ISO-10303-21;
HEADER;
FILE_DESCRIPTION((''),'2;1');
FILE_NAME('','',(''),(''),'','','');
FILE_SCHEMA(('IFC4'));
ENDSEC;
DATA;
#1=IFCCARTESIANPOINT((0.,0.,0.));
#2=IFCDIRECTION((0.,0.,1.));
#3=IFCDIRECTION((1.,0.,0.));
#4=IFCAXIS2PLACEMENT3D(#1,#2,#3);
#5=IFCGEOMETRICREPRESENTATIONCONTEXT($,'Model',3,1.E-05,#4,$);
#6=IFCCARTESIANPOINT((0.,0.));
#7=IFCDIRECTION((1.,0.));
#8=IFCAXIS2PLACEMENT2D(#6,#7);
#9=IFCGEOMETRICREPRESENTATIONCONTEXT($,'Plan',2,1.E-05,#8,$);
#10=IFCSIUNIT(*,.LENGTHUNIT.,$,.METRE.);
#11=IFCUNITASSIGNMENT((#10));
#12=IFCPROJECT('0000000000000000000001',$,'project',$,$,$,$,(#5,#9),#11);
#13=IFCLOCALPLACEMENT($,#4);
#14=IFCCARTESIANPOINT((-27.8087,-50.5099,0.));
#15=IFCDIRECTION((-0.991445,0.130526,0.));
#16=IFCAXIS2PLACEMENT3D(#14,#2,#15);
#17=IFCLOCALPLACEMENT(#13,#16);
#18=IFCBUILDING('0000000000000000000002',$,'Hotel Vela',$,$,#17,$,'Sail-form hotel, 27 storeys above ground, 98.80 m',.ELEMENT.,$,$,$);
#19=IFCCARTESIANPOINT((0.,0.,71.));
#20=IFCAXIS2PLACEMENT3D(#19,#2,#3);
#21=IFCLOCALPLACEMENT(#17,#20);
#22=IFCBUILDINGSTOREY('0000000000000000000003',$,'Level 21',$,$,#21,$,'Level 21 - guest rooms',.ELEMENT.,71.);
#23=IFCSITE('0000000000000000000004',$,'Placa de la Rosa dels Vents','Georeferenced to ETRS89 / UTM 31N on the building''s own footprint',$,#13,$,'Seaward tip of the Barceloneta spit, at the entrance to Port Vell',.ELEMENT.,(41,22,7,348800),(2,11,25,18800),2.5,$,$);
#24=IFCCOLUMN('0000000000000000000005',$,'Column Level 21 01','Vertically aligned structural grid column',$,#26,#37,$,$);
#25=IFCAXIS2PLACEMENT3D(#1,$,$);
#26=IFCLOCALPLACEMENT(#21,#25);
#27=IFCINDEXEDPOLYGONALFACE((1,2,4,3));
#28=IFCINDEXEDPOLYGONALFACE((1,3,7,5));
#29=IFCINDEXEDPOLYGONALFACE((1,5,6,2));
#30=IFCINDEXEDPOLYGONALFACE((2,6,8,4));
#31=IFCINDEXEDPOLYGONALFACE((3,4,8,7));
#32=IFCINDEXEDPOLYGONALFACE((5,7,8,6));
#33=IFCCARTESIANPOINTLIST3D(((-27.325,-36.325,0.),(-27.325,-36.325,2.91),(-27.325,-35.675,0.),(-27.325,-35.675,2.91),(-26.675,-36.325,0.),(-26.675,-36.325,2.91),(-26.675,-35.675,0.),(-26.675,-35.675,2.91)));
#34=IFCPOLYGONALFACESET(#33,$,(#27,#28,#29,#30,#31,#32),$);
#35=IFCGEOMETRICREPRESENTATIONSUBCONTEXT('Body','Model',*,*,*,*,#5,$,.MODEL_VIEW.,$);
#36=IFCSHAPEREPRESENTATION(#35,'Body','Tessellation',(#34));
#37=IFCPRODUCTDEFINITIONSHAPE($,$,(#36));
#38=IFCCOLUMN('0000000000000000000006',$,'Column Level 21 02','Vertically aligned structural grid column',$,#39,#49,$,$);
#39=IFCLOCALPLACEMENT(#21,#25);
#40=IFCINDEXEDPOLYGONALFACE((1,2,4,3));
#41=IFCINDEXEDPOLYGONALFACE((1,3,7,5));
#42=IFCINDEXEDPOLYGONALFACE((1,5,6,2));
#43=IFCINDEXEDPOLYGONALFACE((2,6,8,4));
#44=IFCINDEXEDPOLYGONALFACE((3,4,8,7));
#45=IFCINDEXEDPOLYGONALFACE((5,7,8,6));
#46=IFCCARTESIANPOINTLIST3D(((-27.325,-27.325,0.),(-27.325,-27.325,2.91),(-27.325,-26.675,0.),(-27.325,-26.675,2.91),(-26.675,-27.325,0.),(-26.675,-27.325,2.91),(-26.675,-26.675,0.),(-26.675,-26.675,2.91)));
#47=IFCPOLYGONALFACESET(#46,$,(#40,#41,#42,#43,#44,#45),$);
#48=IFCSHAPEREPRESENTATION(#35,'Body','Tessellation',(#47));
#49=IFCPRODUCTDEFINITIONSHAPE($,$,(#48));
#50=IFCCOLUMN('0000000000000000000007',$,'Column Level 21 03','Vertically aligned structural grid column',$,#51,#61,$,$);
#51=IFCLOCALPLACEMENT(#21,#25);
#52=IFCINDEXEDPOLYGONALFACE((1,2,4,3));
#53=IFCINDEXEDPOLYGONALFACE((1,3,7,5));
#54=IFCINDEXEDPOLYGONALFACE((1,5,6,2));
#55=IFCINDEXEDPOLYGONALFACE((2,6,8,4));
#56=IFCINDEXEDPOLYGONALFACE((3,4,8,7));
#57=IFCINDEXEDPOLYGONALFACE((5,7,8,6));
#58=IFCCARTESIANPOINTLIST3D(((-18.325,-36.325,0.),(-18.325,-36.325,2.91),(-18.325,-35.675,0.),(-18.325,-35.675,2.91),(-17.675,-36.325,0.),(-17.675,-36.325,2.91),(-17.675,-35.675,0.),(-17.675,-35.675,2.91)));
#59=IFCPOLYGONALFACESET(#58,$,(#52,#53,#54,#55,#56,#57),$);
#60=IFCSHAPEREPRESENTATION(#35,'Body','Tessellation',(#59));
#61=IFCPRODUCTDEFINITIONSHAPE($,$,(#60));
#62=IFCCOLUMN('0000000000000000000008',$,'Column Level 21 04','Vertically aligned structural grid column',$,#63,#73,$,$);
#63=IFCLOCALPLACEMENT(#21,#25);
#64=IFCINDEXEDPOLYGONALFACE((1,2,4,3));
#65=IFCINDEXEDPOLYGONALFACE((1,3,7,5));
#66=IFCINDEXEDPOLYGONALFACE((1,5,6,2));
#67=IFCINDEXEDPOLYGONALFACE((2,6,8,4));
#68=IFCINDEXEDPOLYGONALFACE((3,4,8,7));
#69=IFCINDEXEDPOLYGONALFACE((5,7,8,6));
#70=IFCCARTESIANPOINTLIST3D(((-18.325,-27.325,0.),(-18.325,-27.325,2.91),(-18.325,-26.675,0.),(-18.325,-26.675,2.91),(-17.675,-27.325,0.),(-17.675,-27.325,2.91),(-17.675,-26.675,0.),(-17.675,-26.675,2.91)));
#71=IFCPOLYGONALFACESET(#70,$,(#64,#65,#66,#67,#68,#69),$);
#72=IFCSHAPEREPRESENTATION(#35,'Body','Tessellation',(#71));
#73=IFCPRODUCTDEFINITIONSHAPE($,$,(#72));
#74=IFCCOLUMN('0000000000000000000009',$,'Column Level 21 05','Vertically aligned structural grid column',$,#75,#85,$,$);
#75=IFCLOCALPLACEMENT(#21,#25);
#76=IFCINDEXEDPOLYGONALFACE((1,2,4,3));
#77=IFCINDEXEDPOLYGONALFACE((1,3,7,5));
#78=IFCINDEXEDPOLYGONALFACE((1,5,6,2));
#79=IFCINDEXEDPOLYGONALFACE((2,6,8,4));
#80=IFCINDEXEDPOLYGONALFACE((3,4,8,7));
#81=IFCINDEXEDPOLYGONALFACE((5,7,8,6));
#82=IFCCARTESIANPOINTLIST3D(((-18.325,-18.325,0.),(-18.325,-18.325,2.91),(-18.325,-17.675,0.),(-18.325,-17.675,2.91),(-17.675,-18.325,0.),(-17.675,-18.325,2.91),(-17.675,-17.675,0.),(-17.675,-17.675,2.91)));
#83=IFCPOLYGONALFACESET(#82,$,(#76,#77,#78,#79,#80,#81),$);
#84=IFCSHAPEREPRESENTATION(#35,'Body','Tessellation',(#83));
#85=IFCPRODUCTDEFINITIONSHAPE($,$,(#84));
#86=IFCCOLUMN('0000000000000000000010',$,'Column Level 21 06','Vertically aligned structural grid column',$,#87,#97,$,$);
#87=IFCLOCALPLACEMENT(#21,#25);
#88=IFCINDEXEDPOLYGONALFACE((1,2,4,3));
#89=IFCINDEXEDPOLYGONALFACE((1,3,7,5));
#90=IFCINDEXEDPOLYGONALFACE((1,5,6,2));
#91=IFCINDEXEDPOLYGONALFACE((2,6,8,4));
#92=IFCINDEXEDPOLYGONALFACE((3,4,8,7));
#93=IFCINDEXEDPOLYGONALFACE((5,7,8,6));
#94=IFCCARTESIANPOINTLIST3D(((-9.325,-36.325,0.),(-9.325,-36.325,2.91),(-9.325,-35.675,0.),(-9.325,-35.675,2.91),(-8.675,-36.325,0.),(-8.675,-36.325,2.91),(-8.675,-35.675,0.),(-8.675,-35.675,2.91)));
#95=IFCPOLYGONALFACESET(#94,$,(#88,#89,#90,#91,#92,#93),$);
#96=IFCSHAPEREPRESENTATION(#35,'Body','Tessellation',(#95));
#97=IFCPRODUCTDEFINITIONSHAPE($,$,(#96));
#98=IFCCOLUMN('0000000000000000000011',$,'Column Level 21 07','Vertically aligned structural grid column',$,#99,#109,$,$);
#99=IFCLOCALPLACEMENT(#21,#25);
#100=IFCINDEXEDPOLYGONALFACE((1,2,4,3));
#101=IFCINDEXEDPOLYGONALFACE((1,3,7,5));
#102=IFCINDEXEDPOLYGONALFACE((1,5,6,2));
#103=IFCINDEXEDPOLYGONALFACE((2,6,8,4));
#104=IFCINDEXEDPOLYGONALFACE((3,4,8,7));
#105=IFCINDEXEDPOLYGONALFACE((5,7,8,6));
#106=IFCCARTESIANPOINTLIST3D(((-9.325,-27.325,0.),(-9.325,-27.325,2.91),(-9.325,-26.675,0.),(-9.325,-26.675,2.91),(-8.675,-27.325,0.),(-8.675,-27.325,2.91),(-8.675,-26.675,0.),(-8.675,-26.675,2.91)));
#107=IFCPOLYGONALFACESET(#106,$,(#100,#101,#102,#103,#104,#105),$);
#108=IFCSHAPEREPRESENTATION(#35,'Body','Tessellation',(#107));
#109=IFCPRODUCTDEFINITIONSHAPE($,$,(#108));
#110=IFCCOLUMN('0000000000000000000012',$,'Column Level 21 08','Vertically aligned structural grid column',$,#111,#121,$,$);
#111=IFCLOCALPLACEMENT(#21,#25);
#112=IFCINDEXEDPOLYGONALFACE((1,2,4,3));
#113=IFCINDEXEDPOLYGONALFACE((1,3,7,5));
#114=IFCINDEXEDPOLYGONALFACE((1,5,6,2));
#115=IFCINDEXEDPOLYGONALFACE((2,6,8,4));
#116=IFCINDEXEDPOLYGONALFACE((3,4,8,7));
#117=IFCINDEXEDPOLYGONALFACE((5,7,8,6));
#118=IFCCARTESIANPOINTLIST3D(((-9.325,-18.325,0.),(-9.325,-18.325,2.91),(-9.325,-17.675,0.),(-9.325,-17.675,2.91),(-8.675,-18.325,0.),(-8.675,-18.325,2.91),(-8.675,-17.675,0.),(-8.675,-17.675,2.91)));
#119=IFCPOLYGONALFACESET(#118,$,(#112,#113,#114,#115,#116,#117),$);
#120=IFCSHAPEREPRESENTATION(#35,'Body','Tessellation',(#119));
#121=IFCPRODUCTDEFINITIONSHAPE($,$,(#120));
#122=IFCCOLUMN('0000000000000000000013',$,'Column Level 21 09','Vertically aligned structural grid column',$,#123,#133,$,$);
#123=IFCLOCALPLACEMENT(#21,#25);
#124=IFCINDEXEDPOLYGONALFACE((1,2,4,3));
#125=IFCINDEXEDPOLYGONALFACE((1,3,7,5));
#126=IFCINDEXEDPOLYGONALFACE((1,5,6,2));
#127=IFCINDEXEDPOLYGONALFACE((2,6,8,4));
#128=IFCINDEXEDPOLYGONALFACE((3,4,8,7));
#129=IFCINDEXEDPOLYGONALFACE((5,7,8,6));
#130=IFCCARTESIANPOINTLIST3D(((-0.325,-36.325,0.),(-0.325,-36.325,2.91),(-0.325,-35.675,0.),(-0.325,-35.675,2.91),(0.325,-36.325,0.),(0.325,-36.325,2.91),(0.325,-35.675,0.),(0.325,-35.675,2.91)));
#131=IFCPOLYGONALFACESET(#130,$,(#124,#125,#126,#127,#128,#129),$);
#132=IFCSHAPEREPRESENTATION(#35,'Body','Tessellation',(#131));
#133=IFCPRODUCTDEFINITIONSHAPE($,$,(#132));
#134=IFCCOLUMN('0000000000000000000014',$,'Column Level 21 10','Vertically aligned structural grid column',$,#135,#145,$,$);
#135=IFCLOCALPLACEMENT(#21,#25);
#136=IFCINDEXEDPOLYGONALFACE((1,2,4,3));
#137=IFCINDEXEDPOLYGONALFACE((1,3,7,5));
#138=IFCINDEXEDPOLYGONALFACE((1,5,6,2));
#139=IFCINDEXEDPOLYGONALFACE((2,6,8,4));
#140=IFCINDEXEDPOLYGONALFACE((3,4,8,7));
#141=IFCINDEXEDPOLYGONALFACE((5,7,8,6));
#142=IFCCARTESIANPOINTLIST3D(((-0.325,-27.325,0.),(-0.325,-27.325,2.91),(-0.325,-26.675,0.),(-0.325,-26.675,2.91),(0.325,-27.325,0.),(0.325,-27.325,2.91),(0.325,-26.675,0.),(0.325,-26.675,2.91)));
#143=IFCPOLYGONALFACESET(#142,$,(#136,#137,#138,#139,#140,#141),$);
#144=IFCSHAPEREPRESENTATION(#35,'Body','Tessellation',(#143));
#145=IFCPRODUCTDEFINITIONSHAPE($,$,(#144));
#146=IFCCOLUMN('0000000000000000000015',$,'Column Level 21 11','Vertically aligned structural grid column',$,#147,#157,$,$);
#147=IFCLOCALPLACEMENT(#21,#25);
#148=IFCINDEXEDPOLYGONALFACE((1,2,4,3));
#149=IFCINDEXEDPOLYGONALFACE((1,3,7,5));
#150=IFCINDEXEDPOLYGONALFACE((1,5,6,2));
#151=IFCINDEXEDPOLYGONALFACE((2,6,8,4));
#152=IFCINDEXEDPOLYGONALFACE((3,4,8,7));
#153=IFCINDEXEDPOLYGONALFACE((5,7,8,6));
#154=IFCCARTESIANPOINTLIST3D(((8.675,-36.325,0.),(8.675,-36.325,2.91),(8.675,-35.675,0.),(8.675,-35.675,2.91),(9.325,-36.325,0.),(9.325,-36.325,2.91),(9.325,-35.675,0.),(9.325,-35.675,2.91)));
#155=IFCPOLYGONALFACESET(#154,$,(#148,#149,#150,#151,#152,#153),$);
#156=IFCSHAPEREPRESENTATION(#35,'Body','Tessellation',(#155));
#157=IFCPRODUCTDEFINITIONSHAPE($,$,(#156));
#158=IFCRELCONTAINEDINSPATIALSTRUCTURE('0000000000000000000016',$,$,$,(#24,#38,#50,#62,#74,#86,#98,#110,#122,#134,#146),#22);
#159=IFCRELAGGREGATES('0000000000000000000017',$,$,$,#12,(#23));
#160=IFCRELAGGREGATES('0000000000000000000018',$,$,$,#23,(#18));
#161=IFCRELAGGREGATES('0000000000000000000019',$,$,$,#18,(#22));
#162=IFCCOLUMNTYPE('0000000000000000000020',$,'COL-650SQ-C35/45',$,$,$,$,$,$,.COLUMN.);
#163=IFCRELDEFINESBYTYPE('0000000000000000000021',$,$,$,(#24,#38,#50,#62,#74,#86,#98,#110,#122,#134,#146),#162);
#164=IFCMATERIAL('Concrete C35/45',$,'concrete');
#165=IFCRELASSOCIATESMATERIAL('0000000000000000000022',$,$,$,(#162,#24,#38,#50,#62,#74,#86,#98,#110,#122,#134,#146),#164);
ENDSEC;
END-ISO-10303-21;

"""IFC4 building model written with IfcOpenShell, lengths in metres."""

from ifc_helpers import new_model, si_unit, frame, origin_with_axes, origin_2d_with_axis, place, context, subcontext, project, spatial, line, indexed_curve, rectangle, outline, extrude, material, material_profile, profile_set, profile_usage, type_object, element, save


model = new_model("IFC4")

# Units and contexts
model_context = context("Model", 3, precision=1e-05, world=origin_with_axes())
plan_context = context("Plan", 2, precision=1e-05, world=origin_2d_with_axis())
body_context = subcontext(model_context, "Body", "Model", "MODEL_VIEW")
ifc_project = project(units=[si_unit("LENGTHUNIT", "METRE")], contexts=[model_context, plan_context])

# Site, building, storey
site_placement = place(None, origin_with_axes())
site = spatial("IfcSite", under=ifc_project, at=site_placement, Name="Placa de la Rosa dels Vents", Description="Georeferenced to ETRS89 / UTM 31N on the building's own footprint", LongName="Seaward tip of the Barceloneta spit, at the entrance to Port Vell", CompositionType="ELEMENT", RefLatitude=(41, 22, 7, 348800), RefLongitude=(2, 11, 25, 18800), RefElevation=2.5)
building_placement = place(site_placement, frame((-27.8087, -50.5099, 0.0), z_axis=(0.0, 0.0, 1.0), x_axis=(-0.991445, 0.130526, 0.0)))
building = spatial("IfcBuilding", under=site, at=building_placement, Name="Hotel Vela", LongName="Sail-form hotel, 27 storeys above ground, 98.80 m", CompositionType="ELEMENT")
storey_placement = place(building_placement, frame((0.0, 0.0, 71.0), z_axis=(0.0, 0.0, 1.0), x_axis=(1.0, 0.0, 0.0)))
storey = spatial("IfcBuildingStorey", under=building, at=storey_placement, Name="Level 21", LongName="Level 21 - guest rooms", CompositionType="ELEMENT", Elevation=71.0)

# Columns
ifc_material = material(Name="Concrete C35/45", Category="concrete")
ifc_material_profile = material_profile(ifc_material, rectangle(XDim=0.65, YDim=0.65))
ifc_profile_set = profile_set([ifc_material_profile], Name="COL-650SQ-C35/45")
ifc_profile_usage_1 = profile_usage(ifc_profile_set)
column_type = type_object("IfcColumnType", Name="COL-650SQ-C35/45", PredefinedType="COLUMN", material=ifc_profile_set)
column_1_placement = place(storey_placement, frame((-27.325, -36.325, 0.0), z_axis=(0.0, 0.0, 1.0), x_axis=(1.0, 0.0, 0.0)))
element("IfcColumn", 1, at=column_1_placement, inside=storey, type_object=column_type, material=ifc_profile_usage_1, Name="Column Level 21 01", Description="Vertically aligned structural grid column", context=body_context, shape_type="SweptSolid", body=[
    extrude(outline(indexed_curve([(0.0, 0.0), (0.65, 0.0), (0.65, 0.65), (0.0, 0.65)], segments=[line(1, 2, 3, 4, 1)])), origin_with_axes(), (0.0, 0.0, 1.0), 2.91),
])
ifc_profile_usage_2 = profile_usage(ifc_profile_set)
column_2_placement = place(storey_placement, frame((-27.325, -27.325, 0.0), z_axis=(0.0, 0.0, 1.0), x_axis=(1.0, 0.0, 0.0)))
element("IfcColumn", 2, at=column_2_placement, inside=storey, type_object=column_type, material=ifc_profile_usage_2, Name="Column Level 21 02", Description="Vertically aligned structural grid column", context=body_context, shape_type="SweptSolid", body=[
    extrude(outline(indexed_curve([(0.0, 0.0), (0.65, 0.0), (0.65, 0.65), (0.0, 0.65)], segments=[line(1, 2, 3, 4, 1)])), origin_with_axes(), (0.0, 0.0, 1.0), 2.91),
])
ifc_profile_usage_3 = profile_usage(ifc_profile_set)
column_3_placement = place(storey_placement, frame((-18.325, -36.325, 0.0), z_axis=(0.0, 0.0, 1.0), x_axis=(1.0, 0.0, 0.0)))
element("IfcColumn", 3, at=column_3_placement, inside=storey, type_object=column_type, material=ifc_profile_usage_3, Name="Column Level 21 03", Description="Vertically aligned structural grid column", context=body_context, shape_type="SweptSolid", body=[
    extrude(outline(indexed_curve([(0.0, 0.0), (0.65, 0.0), (0.65, 0.65), (0.0, 0.65)], segments=[line(1, 2, 3, 4, 1)])), origin_with_axes(), (0.0, 0.0, 1.0), 2.91),
])
ifc_profile_usage_4 = profile_usage(ifc_profile_set)
column_4_placement = place(storey_placement, frame((-18.325, -27.325, 0.0), z_axis=(0.0, 0.0, 1.0), x_axis=(1.0, 0.0, 0.0)))
element("IfcColumn", 4, at=column_4_placement, inside=storey, type_object=column_type, material=ifc_profile_usage_4, Name="Column Level 21 04", Description="Vertically aligned structural grid column", context=body_context, shape_type="SweptSolid", body=[
    extrude(outline(indexed_curve([(0.0, 0.0), (0.65, 0.0), (0.65, 0.65), (0.0, 0.65)], segments=[line(1, 2, 3, 4, 1)])), origin_with_axes(), (0.0, 0.0, 1.0), 2.91),
])
ifc_profile_usage_5 = profile_usage(ifc_profile_set)
column_5_placement = place(storey_placement, frame((-18.325, -18.325, 0.0), z_axis=(0.0, 0.0, 1.0), x_axis=(1.0, 0.0, 0.0)))
element("IfcColumn", 5, at=column_5_placement, inside=storey, type_object=column_type, material=ifc_profile_usage_5, Name="Column Level 21 05", Description="Vertically aligned structural grid column", context=body_context, shape_type="SweptSolid", body=[
    extrude(outline(indexed_curve([(0.0, 0.0), (0.65, 0.0), (0.65, 0.65), (0.0, 0.65)], segments=[line(1, 2, 3, 4, 1)])), origin_with_axes(), (0.0, 0.0, 1.0), 2.91),
])
ifc_profile_usage_6 = profile_usage(ifc_profile_set)
column_6_placement = place(storey_placement, frame((-9.325, -36.325, 0.0), z_axis=(0.0, 0.0, 1.0), x_axis=(1.0, 0.0, 0.0)))
element("IfcColumn", 6, at=column_6_placement, inside=storey, type_object=column_type, material=ifc_profile_usage_6, Name="Column Level 21 06", Description="Vertically aligned structural grid column", context=body_context, shape_type="SweptSolid", body=[
    extrude(outline(indexed_curve([(0.0, 0.0), (0.65, 0.0), (0.65, 0.65), (0.0, 0.65)], segments=[line(1, 2, 3, 4, 1)])), origin_with_axes(), (0.0, 0.0, 1.0), 2.91),
])
ifc_profile_usage_7 = profile_usage(ifc_profile_set)
column_7_placement = place(storey_placement, frame((-9.325, -27.325, 0.0), z_axis=(0.0, 0.0, 1.0), x_axis=(1.0, 0.0, 0.0)))
element("IfcColumn", 7, at=column_7_placement, inside=storey, type_object=column_type, material=ifc_profile_usage_7, Name="Column Level 21 07", Description="Vertically aligned structural grid column", context=body_context, shape_type="SweptSolid", body=[
    extrude(outline(indexed_curve([(0.0, 0.0), (0.65, 0.0), (0.65, 0.65), (0.0, 0.65)], segments=[line(1, 2, 3, 4, 1)])), origin_with_axes(), (0.0, 0.0, 1.0), 2.91),
])
ifc_profile_usage_8 = profile_usage(ifc_profile_set)
column_8_placement = place(storey_placement, frame((-9.325, -18.325, 0.0), z_axis=(0.0, 0.0, 1.0), x_axis=(1.0, 0.0, 0.0)))
element("IfcColumn", 8, at=column_8_placement, inside=storey, type_object=column_type, material=ifc_profile_usage_8, Name="Column Level 21 08", Description="Vertically aligned structural grid column", context=body_context, shape_type="SweptSolid", body=[
    extrude(outline(indexed_curve([(0.0, 0.0), (0.65, 0.0), (0.65, 0.65), (0.0, 0.65)], segments=[line(1, 2, 3, 4, 1)])), origin_with_axes(), (0.0, 0.0, 1.0), 2.91),
])
ifc_profile_usage_9 = profile_usage(ifc_profile_set)
column_9_placement = place(storey_placement, frame((-0.325, -36.325, 0.0), z_axis=(0.0, 0.0, 1.0), x_axis=(1.0, 0.0, 0.0)))
element("IfcColumn", 9, at=column_9_placement, inside=storey, type_object=column_type, material=ifc_profile_usage_9, Name="Column Level 21 09", Description="Vertically aligned structural grid column", context=body_context, shape_type="SweptSolid", body=[
    extrude(outline(indexed_curve([(0.0, 0.0), (0.65, 0.0), (0.65, 0.65), (0.0, 0.65)], segments=[line(1, 2, 3, 4, 1)])), origin_with_axes(), (0.0, 0.0, 1.0), 2.91),
])
ifc_profile_usage_10 = profile_usage(ifc_profile_set)
column_10_placement = place(storey_placement, frame((-0.325, -27.325, 0.0), z_axis=(0.0, 0.0, 1.0), x_axis=(1.0, 0.0, 0.0)))
element("IfcColumn", 10, at=column_10_placement, inside=storey, type_object=column_type, material=ifc_profile_usage_10, Name="Column Level 21 10", Description="Vertically aligned structural grid column", context=body_context, shape_type="SweptSolid", body=[
    extrude(outline(indexed_curve([(0.0, 0.0), (0.65, 0.0), (0.65, 0.65), (0.0, 0.65)], segments=[line(1, 2, 3, 4, 1)])), origin_with_axes(), (0.0, 0.0, 1.0), 2.91),
])
ifc_profile_usage_11 = profile_usage(ifc_profile_set)
column_11_placement = place(storey_placement, frame((8.675, -36.325, 0.0), z_axis=(0.0, 0.0, 1.0), x_axis=(1.0, 0.0, 0.0)))
element("IfcColumn", 11, at=column_11_placement, inside=storey, type_object=column_type, material=ifc_profile_usage_11, Name="Column Level 21 11", Description="Vertically aligned structural grid column", context=body_context, shape_type="SweptSolid", body=[
    extrude(outline(indexed_curve([(0.0, 0.0), (0.65, 0.0), (0.65, 0.65), (0.0, 0.65)], segments=[line(1, 2, 3, 4, 1)])), origin_with_axes(), (0.0, 0.0, 1.0), 2.91),
])

save(model, "model.ifc")
